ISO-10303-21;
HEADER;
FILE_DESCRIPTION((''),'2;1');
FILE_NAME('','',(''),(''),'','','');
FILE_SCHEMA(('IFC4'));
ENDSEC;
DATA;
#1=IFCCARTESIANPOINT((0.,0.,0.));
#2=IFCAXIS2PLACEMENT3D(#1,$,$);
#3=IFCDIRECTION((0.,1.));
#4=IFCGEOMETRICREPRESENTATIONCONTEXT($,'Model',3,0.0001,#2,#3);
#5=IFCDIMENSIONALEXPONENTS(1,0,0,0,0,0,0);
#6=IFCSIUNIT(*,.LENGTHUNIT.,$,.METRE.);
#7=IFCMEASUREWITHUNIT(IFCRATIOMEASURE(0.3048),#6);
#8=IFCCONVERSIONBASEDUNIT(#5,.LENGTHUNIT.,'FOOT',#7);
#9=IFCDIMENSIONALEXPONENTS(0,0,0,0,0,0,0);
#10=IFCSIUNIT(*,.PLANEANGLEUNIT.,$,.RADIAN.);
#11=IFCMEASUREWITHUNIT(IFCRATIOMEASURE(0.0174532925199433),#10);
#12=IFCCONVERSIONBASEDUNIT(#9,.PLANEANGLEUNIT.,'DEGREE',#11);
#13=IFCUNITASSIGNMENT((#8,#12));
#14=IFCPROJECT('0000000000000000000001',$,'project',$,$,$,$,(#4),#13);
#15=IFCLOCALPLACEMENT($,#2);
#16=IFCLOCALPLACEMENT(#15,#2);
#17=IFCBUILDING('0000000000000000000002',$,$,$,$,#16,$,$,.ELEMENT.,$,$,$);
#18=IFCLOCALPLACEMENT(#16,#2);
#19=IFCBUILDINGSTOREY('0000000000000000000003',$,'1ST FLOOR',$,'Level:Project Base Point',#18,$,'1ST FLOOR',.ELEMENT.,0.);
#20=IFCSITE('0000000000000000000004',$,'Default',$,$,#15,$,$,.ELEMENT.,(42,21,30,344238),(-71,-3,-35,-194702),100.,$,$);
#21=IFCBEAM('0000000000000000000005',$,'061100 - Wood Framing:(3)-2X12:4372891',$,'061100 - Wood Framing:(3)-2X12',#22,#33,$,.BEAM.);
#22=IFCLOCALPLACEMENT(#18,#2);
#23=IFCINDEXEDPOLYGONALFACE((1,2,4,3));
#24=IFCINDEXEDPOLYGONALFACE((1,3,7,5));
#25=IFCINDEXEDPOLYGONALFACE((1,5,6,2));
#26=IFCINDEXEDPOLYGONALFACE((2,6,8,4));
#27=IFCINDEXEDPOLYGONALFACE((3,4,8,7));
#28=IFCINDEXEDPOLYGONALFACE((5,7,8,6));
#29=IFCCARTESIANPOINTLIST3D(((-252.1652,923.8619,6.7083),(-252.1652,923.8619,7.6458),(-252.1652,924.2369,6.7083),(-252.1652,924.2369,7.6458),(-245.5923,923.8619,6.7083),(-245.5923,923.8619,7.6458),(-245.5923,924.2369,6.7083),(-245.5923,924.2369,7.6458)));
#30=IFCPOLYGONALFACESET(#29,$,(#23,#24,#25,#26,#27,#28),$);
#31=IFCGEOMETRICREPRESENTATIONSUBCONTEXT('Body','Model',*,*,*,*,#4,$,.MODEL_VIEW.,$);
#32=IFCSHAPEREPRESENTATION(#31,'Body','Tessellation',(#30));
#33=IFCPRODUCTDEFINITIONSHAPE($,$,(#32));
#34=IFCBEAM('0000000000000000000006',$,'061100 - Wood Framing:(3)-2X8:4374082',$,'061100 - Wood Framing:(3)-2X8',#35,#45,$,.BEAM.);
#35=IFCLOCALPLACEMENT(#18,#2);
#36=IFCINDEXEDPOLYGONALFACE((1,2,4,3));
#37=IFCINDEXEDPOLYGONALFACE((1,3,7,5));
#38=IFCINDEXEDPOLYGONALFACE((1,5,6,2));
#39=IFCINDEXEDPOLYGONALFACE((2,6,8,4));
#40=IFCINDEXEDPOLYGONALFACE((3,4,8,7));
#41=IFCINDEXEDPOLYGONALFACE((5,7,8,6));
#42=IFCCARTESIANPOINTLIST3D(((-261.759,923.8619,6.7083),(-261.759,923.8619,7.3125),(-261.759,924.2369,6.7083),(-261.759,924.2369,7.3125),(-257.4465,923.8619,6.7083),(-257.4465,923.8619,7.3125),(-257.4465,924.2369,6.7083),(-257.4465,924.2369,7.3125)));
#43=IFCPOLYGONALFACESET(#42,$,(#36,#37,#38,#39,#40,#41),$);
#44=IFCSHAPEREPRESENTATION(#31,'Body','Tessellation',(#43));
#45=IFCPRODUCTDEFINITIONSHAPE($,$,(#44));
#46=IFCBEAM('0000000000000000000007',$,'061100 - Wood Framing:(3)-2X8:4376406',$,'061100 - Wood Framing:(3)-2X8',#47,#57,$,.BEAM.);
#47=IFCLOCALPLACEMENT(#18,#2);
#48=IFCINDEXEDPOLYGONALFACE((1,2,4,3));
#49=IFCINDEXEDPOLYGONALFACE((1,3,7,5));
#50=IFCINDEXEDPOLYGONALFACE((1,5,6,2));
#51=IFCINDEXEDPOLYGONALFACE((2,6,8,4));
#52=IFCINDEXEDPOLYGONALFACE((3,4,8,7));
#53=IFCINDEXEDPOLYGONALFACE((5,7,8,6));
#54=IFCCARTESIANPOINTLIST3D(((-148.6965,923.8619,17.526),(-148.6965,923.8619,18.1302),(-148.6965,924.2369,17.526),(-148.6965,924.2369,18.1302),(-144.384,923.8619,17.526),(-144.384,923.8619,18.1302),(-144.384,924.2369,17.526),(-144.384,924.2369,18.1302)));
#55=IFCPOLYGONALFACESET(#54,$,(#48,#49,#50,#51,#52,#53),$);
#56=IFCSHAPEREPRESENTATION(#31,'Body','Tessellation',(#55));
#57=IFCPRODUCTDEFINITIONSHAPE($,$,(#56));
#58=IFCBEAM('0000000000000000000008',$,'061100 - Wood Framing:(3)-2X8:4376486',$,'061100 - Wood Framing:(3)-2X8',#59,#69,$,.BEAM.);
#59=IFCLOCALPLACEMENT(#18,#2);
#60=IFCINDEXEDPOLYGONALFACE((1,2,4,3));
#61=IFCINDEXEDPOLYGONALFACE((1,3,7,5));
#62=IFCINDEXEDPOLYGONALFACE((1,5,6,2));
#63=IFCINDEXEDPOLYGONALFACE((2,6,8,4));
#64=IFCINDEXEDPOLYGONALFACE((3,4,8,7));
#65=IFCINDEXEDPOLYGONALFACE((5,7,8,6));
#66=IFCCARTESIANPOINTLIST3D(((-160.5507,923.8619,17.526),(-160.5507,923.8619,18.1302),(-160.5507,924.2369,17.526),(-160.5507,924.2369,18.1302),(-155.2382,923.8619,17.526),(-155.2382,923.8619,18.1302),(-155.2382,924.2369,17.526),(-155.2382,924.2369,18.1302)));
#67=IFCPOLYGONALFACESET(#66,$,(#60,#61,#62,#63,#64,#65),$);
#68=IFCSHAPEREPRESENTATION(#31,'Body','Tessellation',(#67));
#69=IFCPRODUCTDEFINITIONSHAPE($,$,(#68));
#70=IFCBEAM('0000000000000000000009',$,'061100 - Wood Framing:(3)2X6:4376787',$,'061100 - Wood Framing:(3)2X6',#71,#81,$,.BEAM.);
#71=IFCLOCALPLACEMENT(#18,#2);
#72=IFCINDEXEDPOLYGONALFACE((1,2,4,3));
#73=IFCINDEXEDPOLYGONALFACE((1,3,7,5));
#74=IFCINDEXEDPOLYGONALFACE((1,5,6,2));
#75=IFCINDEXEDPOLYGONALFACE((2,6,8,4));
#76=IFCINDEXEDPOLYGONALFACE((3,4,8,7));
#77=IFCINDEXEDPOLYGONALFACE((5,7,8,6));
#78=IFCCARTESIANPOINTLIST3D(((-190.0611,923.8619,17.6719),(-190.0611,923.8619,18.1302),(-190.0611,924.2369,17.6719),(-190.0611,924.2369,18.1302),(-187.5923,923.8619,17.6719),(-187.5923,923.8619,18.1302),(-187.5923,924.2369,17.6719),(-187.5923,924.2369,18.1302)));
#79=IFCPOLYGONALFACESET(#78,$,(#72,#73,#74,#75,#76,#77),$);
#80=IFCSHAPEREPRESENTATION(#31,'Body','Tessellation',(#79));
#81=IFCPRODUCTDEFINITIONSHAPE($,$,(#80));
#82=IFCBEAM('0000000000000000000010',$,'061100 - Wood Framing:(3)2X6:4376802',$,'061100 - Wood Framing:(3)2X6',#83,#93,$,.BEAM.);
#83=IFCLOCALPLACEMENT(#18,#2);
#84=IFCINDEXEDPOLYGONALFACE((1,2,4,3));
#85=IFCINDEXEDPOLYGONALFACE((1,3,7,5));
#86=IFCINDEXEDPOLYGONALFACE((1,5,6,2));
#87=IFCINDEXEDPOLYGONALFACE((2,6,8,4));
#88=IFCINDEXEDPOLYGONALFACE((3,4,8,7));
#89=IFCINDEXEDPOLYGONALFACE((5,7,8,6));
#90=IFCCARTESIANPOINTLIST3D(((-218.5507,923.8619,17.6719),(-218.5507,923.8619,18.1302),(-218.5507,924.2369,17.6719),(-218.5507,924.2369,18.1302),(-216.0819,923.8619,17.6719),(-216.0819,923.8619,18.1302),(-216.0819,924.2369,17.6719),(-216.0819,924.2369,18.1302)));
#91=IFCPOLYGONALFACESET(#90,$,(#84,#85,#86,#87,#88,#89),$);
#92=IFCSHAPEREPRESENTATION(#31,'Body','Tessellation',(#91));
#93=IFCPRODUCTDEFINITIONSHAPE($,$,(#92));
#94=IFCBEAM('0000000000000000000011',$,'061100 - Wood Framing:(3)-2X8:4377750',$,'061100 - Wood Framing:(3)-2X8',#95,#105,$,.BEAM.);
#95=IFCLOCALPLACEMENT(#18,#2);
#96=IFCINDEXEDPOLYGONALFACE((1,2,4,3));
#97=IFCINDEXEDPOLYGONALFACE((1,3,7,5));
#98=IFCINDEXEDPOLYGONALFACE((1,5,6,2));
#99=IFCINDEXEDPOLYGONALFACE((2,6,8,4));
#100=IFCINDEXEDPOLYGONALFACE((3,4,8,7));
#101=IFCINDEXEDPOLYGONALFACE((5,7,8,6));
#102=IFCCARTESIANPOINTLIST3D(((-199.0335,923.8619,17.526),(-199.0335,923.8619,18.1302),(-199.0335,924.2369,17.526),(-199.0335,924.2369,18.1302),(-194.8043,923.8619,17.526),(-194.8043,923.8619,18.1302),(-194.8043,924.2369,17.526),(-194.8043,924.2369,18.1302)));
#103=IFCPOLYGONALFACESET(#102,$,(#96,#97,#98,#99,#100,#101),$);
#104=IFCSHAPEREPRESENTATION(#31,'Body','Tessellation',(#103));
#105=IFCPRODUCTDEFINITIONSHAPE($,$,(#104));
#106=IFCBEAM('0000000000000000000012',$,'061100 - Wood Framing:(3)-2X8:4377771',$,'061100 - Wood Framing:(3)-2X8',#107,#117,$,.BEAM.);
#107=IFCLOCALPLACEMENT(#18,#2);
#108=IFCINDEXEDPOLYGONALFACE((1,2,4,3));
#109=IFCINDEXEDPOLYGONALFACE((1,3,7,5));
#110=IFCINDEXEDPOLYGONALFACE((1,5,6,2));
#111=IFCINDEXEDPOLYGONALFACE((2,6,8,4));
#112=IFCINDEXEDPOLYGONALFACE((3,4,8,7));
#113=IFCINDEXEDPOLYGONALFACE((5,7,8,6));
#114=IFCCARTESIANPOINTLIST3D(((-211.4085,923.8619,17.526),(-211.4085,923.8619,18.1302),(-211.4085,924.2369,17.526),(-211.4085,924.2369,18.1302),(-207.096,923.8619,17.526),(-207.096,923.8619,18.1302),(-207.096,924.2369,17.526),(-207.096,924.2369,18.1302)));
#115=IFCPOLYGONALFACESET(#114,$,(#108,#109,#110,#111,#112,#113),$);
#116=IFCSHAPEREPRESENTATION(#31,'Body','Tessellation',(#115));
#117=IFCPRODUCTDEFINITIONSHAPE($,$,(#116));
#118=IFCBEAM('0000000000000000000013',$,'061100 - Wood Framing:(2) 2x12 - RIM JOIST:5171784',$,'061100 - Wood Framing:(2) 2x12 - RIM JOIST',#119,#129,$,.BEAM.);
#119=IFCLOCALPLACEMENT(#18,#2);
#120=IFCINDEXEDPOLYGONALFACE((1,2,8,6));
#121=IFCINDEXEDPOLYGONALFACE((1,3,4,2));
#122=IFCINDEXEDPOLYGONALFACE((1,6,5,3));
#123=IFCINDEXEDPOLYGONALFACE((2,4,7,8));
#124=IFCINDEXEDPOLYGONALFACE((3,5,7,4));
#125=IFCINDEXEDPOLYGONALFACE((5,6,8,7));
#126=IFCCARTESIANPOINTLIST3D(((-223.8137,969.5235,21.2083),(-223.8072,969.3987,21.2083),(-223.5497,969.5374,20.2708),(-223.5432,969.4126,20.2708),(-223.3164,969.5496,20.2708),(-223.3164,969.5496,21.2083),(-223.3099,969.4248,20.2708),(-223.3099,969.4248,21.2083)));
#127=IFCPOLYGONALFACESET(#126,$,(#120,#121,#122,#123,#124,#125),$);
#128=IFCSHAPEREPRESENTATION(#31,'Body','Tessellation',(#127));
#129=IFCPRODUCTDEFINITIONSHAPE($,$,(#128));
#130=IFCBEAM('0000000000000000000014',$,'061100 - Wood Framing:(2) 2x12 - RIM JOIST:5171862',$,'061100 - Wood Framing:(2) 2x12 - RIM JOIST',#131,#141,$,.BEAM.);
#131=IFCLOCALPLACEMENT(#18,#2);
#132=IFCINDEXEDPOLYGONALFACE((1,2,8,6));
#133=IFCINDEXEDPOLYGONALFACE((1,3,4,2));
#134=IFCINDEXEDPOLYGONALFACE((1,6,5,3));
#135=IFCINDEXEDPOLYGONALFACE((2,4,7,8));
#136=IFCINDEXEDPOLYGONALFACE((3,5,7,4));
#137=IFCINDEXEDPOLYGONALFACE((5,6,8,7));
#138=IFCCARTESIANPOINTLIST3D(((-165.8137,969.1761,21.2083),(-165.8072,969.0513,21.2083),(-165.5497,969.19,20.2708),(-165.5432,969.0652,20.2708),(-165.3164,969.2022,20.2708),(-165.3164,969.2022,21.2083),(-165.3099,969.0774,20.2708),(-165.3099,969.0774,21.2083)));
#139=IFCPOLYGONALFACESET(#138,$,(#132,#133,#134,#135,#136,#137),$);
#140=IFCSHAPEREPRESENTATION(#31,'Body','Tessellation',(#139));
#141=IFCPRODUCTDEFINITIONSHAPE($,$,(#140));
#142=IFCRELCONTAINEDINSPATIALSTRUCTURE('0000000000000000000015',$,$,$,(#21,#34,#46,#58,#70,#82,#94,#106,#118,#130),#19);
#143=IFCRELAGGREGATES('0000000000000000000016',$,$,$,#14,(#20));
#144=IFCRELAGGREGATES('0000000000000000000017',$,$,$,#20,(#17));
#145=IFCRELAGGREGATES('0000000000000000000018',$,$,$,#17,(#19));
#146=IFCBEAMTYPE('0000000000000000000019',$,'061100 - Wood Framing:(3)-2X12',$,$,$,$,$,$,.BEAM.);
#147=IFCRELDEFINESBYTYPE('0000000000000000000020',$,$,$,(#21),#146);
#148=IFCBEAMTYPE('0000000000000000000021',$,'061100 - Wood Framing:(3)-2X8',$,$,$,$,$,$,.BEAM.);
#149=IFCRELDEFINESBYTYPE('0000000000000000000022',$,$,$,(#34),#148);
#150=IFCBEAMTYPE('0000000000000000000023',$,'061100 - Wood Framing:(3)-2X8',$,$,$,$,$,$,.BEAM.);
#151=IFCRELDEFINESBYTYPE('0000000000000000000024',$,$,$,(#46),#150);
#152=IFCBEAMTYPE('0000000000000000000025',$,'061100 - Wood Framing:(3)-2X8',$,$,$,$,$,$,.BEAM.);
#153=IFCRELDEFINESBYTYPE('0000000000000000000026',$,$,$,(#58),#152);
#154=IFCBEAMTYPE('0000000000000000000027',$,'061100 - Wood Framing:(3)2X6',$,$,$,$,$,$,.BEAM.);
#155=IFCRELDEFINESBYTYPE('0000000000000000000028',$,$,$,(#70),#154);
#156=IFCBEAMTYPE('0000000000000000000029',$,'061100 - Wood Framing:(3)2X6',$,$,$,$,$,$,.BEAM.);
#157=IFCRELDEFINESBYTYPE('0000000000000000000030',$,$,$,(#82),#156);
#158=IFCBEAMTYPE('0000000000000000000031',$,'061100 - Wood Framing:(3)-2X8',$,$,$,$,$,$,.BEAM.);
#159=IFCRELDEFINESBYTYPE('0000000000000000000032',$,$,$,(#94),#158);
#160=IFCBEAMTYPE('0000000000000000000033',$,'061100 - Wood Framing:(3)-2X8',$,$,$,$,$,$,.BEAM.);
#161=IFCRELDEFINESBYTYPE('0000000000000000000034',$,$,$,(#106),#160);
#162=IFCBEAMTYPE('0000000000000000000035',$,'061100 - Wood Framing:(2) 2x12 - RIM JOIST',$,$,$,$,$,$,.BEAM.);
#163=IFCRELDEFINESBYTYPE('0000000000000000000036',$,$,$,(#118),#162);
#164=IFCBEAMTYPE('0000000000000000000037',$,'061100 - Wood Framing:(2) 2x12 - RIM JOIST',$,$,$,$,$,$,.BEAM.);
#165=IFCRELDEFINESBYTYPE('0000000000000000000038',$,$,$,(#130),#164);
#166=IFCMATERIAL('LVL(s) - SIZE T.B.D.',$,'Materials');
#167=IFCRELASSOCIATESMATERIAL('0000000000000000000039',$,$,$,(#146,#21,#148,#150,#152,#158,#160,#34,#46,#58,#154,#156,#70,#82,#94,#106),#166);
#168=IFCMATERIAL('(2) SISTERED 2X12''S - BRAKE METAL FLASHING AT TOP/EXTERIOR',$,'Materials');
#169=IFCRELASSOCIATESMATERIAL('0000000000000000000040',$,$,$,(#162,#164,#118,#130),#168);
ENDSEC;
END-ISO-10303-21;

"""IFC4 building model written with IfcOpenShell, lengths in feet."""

from ifc_helpers import new_model, entity, si_unit, converted_unit, direction, frame, frame_2d, origin, place, context, subcontext, project, spatial, rectangle, extrude, clip, halfspace, source, transform, mapped, material, material_profile, profile_set, profile_usage, type_object, type_shapes, element, save


model = new_model("IFC4")

# Units and contexts
model_context = context("Model", 3, precision=0.0001, world=origin(), true_north=direction((0.0, 1.0)))
body_context = subcontext(model_context, "Body", "Model", "MODEL_VIEW")
ifc_project = project(units=[converted_unit("LENGTHUNIT", "FOOT", entity("IfcRatioMeasure", 0.3048), si_unit("LENGTHUNIT", "METRE"), dimensions=[1, 0, 0, 0, 0, 0, 0]), converted_unit("PLANEANGLEUNIT", "DEGREE", entity("IfcRatioMeasure", 0.0174532925199433), si_unit("PLANEANGLEUNIT", "RADIAN"), dimensions=[0, 0, 0, 0, 0, 0, 0])], contexts=[model_context])

# Site, building, storey
site_placement = place(None, origin())
site = spatial("IfcSite", under=ifc_project, at=site_placement, Name="Default", CompositionType="ELEMENT", RefLatitude=(42, 21, 30, 344238), RefLongitude=(-71, -3, -35, -194702), RefElevation=100.0)
building_placement = place(site_placement, origin())
building = spatial("IfcBuilding", under=site, at=building_placement, CompositionType="ELEMENT")
storey_placement = place(building_placement, origin())
storey = spatial("IfcBuildingStorey", under=building, at=storey_placement, Name="1ST FLOOR", ObjectType="Level:Project Base Point", LongName="1ST FLOOR", CompositionType="ELEMENT", Elevation=0.0)

# Beams
ifc_material_1 = material(Name="LVL(s) - SIZE T.B.D.", Category="Materials")
ifc_material_profile_1 = material_profile(ifc_material_1, rectangle(XDim=0.9375, YDim=0.375, at=frame_2d((0.0, 0.0), x_axis=(1.0, 0.0))), Name="(3)-2X12")
ifc_profile_set_1 = profile_set([ifc_material_profile_1], Name="(3)-2X12")
ifc_profile_usage_1 = profile_usage(ifc_profile_set_1, cardinal=8)
beam_type_1 = type_object("IfcBeamType", Name="061100 - Wood Framing:(3)-2X12", PredefinedType="BEAM", material=ifc_profile_set_1)
shared_shape_1 = source(origin(), body_context, "Body", "SweptSolid", [
    extrude(rectangle(XDim=0.9375, YDim=0.375, at=frame_2d((0.0, 0.0), x_axis=(1.0, 0.0))), frame((-3.2765, 0.0, 0.0), z_axis=(1.0, 0.0, 0.0), x_axis=(0.0, 0.0, -1.0)), (0.0, 0.0, 1.0), 6.5729),
])
type_shapes(beam_type_1, [shared_shape_1])
beam_1_placement = place(storey_placement, frame((-248.8888, 924.0494, 7.1771)))
element("IfcBeam", 1, at=beam_1_placement, inside=storey, type_object=beam_type_1, material=ifc_profile_usage_1, Name="061100 - Wood Framing:(3)-2X12:4372891", ObjectType="061100 - Wood Framing:(3)-2X12", PredefinedType="BEAM", context=body_context, shape_type="MappedRepresentation", body=[
    mapped(shared_shape_1, transform((0.0, 0.0, 0.0), scale=1.0)),
])
ifc_material_profile_2 = material_profile(ifc_material_1, rectangle(XDim=0.6042, YDim=0.375, at=frame_2d((0.0, 0.0), x_axis=(1.0, 0.0))), Name="(3)-2X8")
ifc_profile_set_2 = profile_set([ifc_material_profile_2], Name="(3)-2X8")
ifc_profile_usage_2 = profile_usage(ifc_profile_set_2, cardinal=8)
beam_type_2 = type_object("IfcBeamType", Name="061100 - Wood Framing:(3)-2X8", PredefinedType="BEAM", material=ifc_profile_set_2)
shared_shape_2 = source(origin(), body_context, "Body", "SweptSolid", [
    extrude(rectangle(XDim=0.6042, YDim=0.375, at=frame_2d((0.0, 0.0), x_axis=(1.0, 0.0))), frame((-2.1594, 0.0, 0.0), z_axis=(1.0, 0.0, 0.0), x_axis=(0.0, 0.0, -1.0)), (0.0, 0.0, 1.0), 4.3125),
])
type_shapes(beam_type_2, [shared_shape_2])
beam_2_placement = place(storey_placement, frame((-259.5996, 924.0494, 7.0104)))
element("IfcBeam", 2, at=beam_2_placement, inside=storey, type_object=beam_type_2, material=ifc_profile_usage_2, Name="061100 - Wood Framing:(3)-2X8:4374082", ObjectType="061100 - Wood Framing:(3)-2X8", PredefinedType="BEAM", context=body_context, shape_type="MappedRepresentation", body=[
    mapped(shared_shape_2, transform((0.0, 0.0, 0.0), scale=1.0)),
])
ifc_profile_usage_3 = profile_usage(ifc_profile_set_2, cardinal=8)
beam_type_3 = type_object("IfcBeamType", Name="061100 - Wood Framing:(3)-2X8", PredefinedType="BEAM", material=ifc_profile_set_2)
shared_shape_3 = source(origin(), body_context, "Body", "SweptSolid", [
    extrude(rectangle(XDim=0.6042, YDim=0.375, at=frame_2d((0.0, 0.0), x_axis=(1.0, 0.0))), frame((-2.1777, 0.0, 0.0), z_axis=(1.0, 0.0, 0.0), x_axis=(0.0, 0.0, -1.0)), (0.0, 0.0, 1.0), 4.3125),
])
type_shapes(beam_type_3, [shared_shape_3])
beam_3_placement = place(storey_placement, frame((-146.5188, 924.0494, 17.8281)))
element("IfcBeam", 3, at=beam_3_placement, inside=storey, type_object=beam_type_3, material=ifc_profile_usage_3, Name="061100 - Wood Framing:(3)-2X8:4376406", ObjectType="061100 - Wood Framing:(3)-2X8", PredefinedType="BEAM", context=body_context, shape_type="MappedRepresentation", body=[
    mapped(shared_shape_3, transform((0.0, 0.0, 0.0), scale=1.0)),
])
ifc_profile_usage_4 = profile_usage(ifc_profile_set_2, cardinal=8)
beam_type_4 = type_object("IfcBeamType", Name="061100 - Wood Framing:(3)-2X8", PredefinedType="BEAM", material=ifc_profile_set_2)
shared_shape_4 = source(origin(), body_context, "Body", "SweptSolid", [
    extrude(rectangle(XDim=0.6042, YDim=0.375, at=frame_2d((0.0, 0.0), x_axis=(1.0, 0.0))), frame((-2.6596, 0.0, 0.0), z_axis=(1.0, 0.0, 0.0), x_axis=(0.0, 0.0, -1.0)), (0.0, 0.0, 1.0), 5.3125),
])
type_shapes(beam_type_4, [shared_shape_4])
beam_4_placement = place(storey_placement, frame((-157.891, 924.0494, 17.8281)))
element("IfcBeam", 4, at=beam_4_placement, inside=storey, type_object=beam_type_4, material=ifc_profile_usage_4, Name="061100 - Wood Framing:(3)-2X8:4376486", ObjectType="061100 - Wood Framing:(3)-2X8", PredefinedType="BEAM", context=body_context, shape_type="MappedRepresentation", body=[
    mapped(shared_shape_4, transform((0.0, 0.0, 0.0), scale=1.0)),
])
ifc_material_profile_3 = material_profile(ifc_material_1, rectangle(XDim=0.4583, YDim=0.375, at=frame_2d((0.0, 0.0), x_axis=(1.0, 0.0))), Name="(3)2X6")
ifc_profile_set_3 = profile_set([ifc_material_profile_3], Name="(3)2X6")
ifc_profile_usage_5 = profile_usage(ifc_profile_set_3, cardinal=8)
beam_type_5 = type_object("IfcBeamType", Name="061100 - Wood Framing:(3)2X6", PredefinedType="BEAM", material=ifc_profile_set_3)
shared_shape_5 = source(origin(), body_context, "Body", "SweptSolid", [
    extrude(rectangle(XDim=0.4583, YDim=0.375, at=frame_2d((0.0, 0.0), x_axis=(1.0, 0.0))), frame((-1.2286, 0.0, 0.0), z_axis=(1.0, 0.0, 0.0), x_axis=(0.0, 0.0, -1.0)), (0.0, 0.0, 1.0), 2.4687),
])
type_shapes(beam_type_5, [shared_shape_5])
beam_5_placement = place(storey_placement, frame((-188.8325, 924.0494, 17.901)))
element("IfcBeam", 5, at=beam_5_placement, inside=storey, type_object=beam_type_5, material=ifc_profile_usage_5, Name="061100 - Wood Framing:(3)2X6:4376787", ObjectType="061100 - Wood Framing:(3)2X6", PredefinedType="BEAM", context=body_context, shape_type="MappedRepresentation", body=[
    mapped(shared_shape_5, transform((0.0, 0.0, 0.0), scale=1.0)),
])
ifc_profile_usage_6 = profile_usage(ifc_profile_set_3, cardinal=8)
beam_type_6 = type_object("IfcBeamType", Name="061100 - Wood Framing:(3)2X6", PredefinedType="BEAM", material=ifc_profile_set_3)
shared_shape_6 = source(origin(), body_context, "Body", "SweptSolid", [
    extrude(rectangle(XDim=0.4583, YDim=0.375, at=frame_2d((0.0, 0.0), x_axis=(1.0, 0.0))), frame((-1.2212, 0.0, 0.0), z_axis=(1.0, 0.0, 0.0), x_axis=(0.0, 0.0, -1.0)), (0.0, 0.0, 1.0), 2.4687),
])
type_shapes(beam_type_6, [shared_shape_6])
beam_6_placement = place(storey_placement, frame((-217.3294, 924.0494, 17.901)))
element("IfcBeam", 6, at=beam_6_placement, inside=storey, type_object=beam_type_6, material=ifc_profile_usage_6, Name="061100 - Wood Framing:(3)2X6:4376802", ObjectType="061100 - Wood Framing:(3)2X6", PredefinedType="BEAM", context=body_context, shape_type="MappedRepresentation", body=[
    mapped(shared_shape_6, transform((0.0, 0.0, 0.0), scale=1.0)),
])
ifc_profile_usage_7 = profile_usage(ifc_profile_set_2, cardinal=8)
beam_type_7 = type_object("IfcBeamType", Name="061100 - Wood Framing:(3)-2X8", PredefinedType="BEAM", material=ifc_profile_set_2)
shared_shape_7 = source(origin(), body_context, "Body", "SweptSolid", [
    extrude(rectangle(XDim=0.6042, YDim=0.375, at=frame_2d((0.0, 0.0), x_axis=(1.0, 0.0))), frame((-2.136, 0.0, 0.0), z_axis=(1.0, 0.0, 0.0), x_axis=(0.0, 0.0, -1.0)), (0.0, 0.0, 1.0), 4.2292),
])
type_shapes(beam_type_7, [shared_shape_7])
beam_7_placement = place(storey_placement, frame((-196.8975, 924.0494, 17.8281)))
element("IfcBeam", 7, at=beam_7_placement, inside=storey, type_object=beam_type_7, material=ifc_profile_usage_7, Name="061100 - Wood Framing:(3)-2X8:4377750", ObjectType="061100 - Wood Framing:(3)-2X8", PredefinedType="BEAM", context=body_context, shape_type="MappedRepresentation", body=[
    mapped(shared_shape_7, transform((0.0, 0.0, 0.0), scale=1.0)),
])
ifc_profile_usage_8 = profile_usage(ifc_profile_set_2, cardinal=8)
beam_type_8 = type_object("IfcBeamType", Name="061100 - Wood Framing:(3)-2X8", PredefinedType="BEAM", material=ifc_profile_set_2)
shared_shape_8 = source(origin(), body_context, "Body", "SweptSolid", [
    extrude(rectangle(XDim=0.6042, YDim=0.375, at=frame_2d((0.0, 0.0), x_axis=(1.0, 0.0))), frame((-2.1777, 0.0, 0.0), z_axis=(1.0, 0.0, 0.0), x_axis=(0.0, 0.0, -1.0)), (0.0, 0.0, 1.0), 4.3125),
])
type_shapes(beam_type_8, [shared_shape_8])
beam_8_placement = place(storey_placement, frame((-209.2308, 924.0494, 17.8281)))
element("IfcBeam", 8, at=beam_8_placement, inside=storey, type_object=beam_type_8, material=ifc_profile_usage_8, Name="061100 - Wood Framing:(3)-2X8:4377771", ObjectType="061100 - Wood Framing:(3)-2X8", PredefinedType="BEAM", context=body_context, shape_type="MappedRepresentation", body=[
    mapped(shared_shape_8, transform((0.0, 0.0, 0.0), scale=1.0)),
])
ifc_material_2 = material(Name="(2) SISTERED 2X12'S - BRAKE METAL FLASHING AT TOP/EXTERIOR", Category="Materials")
ifc_material_profile_4 = material_profile(ifc_material_2, rectangle(XDim=0.9375, YDim=0.125, at=frame_2d((0.0, 0.0), x_axis=(1.0, 0.0))), Name="(2) 2x12 - RIM JOIST")
ifc_profile_set_4 = profile_set([ifc_material_profile_4], Name="(2) 2x12 - RIM JOIST")
ifc_profile_usage_9 = profile_usage(ifc_profile_set_4, cardinal=2)
beam_type_9 = type_object("IfcBeamType", Name="061100 - Wood Framing:(2) 2x12 - RIM JOIST", PredefinedType="BEAM", material=ifc_profile_set_4)
shared_shape_9 = source(origin(), body_context, "Body", "Clipping", [
    clip(extrude(rectangle(XDim=0.9375, YDim=0.125, at=frame_2d((0.0, 0.0), x_axis=(1.0, 0.0))), frame((-223.8105, 969.4611, 20.7396), z_axis=(0.99863, 0.052336, 0.0), x_axis=(0.0, 0.0, 1.0)), (0.0, 0.0, 1.0), 0.498), halfspace(frame((-223.2632, 966.4176, 19.8354), z_axis=(-0.961136, -0.050371, -0.27144), x_axis=(0.271068, 0.014206, -0.962455)), False)),
])
type_shapes(beam_type_9, [shared_shape_9])
beam_9_placement = place(storey_placement, origin())
element("IfcBeam", 9, at=beam_9_placement, inside=storey, type_object=beam_type_9, material=ifc_profile_usage_9, Name="061100 - Wood Framing:(2) 2x12 - RIM JOIST:5171784", ObjectType="061100 - Wood Framing:(2) 2x12 - RIM JOIST", PredefinedType="BEAM", context=body_context, shape_type="MappedRepresentation", body=[
    mapped(shared_shape_9, transform((0.0, 0.0, 0.0), scale=1.0)),
])
ifc_profile_usage_10 = profile_usage(ifc_profile_set_4, cardinal=2)
beam_type_10 = type_object("IfcBeamType", Name="061100 - Wood Framing:(2) 2x12 - RIM JOIST", PredefinedType="BEAM", material=ifc_profile_set_4)
shared_shape_10 = source(origin(), body_context, "Body", "Clipping", [
    clip(extrude(rectangle(XDim=0.9375, YDim=0.125, at=frame_2d((0.0, 0.0), x_axis=(1.0, 0.0))), frame((-165.8105, 969.1137, 20.7396), z_axis=(0.99863, 0.052336, 0.0), x_axis=(0.0, 0.0, 1.0)), (0.0, 0.0, 1.0), 0.498), halfspace(frame((-165.2632, 966.0702, 19.8354), z_axis=(-0.961136, -0.050371, -0.27144), x_axis=(0.271068, 0.014206, -0.962455)), False)),
])
type_shapes(beam_type_10, [shared_shape_10])
beam_10_placement = place(storey_placement, origin())
element("IfcBeam", 10, at=beam_10_placement, inside=storey, type_object=beam_type_10, material=ifc_profile_usage_10, Name="061100 - Wood Framing:(2) 2x12 - RIM JOIST:5171862", ObjectType="061100 - Wood Framing:(2) 2x12 - RIM JOIST", PredefinedType="BEAM", context=body_context, shape_type="MappedRepresentation", body=[
    mapped(shared_shape_10, transform((0.0, 0.0, 0.0), scale=1.0)),
])

save(model, "model.ifc")
